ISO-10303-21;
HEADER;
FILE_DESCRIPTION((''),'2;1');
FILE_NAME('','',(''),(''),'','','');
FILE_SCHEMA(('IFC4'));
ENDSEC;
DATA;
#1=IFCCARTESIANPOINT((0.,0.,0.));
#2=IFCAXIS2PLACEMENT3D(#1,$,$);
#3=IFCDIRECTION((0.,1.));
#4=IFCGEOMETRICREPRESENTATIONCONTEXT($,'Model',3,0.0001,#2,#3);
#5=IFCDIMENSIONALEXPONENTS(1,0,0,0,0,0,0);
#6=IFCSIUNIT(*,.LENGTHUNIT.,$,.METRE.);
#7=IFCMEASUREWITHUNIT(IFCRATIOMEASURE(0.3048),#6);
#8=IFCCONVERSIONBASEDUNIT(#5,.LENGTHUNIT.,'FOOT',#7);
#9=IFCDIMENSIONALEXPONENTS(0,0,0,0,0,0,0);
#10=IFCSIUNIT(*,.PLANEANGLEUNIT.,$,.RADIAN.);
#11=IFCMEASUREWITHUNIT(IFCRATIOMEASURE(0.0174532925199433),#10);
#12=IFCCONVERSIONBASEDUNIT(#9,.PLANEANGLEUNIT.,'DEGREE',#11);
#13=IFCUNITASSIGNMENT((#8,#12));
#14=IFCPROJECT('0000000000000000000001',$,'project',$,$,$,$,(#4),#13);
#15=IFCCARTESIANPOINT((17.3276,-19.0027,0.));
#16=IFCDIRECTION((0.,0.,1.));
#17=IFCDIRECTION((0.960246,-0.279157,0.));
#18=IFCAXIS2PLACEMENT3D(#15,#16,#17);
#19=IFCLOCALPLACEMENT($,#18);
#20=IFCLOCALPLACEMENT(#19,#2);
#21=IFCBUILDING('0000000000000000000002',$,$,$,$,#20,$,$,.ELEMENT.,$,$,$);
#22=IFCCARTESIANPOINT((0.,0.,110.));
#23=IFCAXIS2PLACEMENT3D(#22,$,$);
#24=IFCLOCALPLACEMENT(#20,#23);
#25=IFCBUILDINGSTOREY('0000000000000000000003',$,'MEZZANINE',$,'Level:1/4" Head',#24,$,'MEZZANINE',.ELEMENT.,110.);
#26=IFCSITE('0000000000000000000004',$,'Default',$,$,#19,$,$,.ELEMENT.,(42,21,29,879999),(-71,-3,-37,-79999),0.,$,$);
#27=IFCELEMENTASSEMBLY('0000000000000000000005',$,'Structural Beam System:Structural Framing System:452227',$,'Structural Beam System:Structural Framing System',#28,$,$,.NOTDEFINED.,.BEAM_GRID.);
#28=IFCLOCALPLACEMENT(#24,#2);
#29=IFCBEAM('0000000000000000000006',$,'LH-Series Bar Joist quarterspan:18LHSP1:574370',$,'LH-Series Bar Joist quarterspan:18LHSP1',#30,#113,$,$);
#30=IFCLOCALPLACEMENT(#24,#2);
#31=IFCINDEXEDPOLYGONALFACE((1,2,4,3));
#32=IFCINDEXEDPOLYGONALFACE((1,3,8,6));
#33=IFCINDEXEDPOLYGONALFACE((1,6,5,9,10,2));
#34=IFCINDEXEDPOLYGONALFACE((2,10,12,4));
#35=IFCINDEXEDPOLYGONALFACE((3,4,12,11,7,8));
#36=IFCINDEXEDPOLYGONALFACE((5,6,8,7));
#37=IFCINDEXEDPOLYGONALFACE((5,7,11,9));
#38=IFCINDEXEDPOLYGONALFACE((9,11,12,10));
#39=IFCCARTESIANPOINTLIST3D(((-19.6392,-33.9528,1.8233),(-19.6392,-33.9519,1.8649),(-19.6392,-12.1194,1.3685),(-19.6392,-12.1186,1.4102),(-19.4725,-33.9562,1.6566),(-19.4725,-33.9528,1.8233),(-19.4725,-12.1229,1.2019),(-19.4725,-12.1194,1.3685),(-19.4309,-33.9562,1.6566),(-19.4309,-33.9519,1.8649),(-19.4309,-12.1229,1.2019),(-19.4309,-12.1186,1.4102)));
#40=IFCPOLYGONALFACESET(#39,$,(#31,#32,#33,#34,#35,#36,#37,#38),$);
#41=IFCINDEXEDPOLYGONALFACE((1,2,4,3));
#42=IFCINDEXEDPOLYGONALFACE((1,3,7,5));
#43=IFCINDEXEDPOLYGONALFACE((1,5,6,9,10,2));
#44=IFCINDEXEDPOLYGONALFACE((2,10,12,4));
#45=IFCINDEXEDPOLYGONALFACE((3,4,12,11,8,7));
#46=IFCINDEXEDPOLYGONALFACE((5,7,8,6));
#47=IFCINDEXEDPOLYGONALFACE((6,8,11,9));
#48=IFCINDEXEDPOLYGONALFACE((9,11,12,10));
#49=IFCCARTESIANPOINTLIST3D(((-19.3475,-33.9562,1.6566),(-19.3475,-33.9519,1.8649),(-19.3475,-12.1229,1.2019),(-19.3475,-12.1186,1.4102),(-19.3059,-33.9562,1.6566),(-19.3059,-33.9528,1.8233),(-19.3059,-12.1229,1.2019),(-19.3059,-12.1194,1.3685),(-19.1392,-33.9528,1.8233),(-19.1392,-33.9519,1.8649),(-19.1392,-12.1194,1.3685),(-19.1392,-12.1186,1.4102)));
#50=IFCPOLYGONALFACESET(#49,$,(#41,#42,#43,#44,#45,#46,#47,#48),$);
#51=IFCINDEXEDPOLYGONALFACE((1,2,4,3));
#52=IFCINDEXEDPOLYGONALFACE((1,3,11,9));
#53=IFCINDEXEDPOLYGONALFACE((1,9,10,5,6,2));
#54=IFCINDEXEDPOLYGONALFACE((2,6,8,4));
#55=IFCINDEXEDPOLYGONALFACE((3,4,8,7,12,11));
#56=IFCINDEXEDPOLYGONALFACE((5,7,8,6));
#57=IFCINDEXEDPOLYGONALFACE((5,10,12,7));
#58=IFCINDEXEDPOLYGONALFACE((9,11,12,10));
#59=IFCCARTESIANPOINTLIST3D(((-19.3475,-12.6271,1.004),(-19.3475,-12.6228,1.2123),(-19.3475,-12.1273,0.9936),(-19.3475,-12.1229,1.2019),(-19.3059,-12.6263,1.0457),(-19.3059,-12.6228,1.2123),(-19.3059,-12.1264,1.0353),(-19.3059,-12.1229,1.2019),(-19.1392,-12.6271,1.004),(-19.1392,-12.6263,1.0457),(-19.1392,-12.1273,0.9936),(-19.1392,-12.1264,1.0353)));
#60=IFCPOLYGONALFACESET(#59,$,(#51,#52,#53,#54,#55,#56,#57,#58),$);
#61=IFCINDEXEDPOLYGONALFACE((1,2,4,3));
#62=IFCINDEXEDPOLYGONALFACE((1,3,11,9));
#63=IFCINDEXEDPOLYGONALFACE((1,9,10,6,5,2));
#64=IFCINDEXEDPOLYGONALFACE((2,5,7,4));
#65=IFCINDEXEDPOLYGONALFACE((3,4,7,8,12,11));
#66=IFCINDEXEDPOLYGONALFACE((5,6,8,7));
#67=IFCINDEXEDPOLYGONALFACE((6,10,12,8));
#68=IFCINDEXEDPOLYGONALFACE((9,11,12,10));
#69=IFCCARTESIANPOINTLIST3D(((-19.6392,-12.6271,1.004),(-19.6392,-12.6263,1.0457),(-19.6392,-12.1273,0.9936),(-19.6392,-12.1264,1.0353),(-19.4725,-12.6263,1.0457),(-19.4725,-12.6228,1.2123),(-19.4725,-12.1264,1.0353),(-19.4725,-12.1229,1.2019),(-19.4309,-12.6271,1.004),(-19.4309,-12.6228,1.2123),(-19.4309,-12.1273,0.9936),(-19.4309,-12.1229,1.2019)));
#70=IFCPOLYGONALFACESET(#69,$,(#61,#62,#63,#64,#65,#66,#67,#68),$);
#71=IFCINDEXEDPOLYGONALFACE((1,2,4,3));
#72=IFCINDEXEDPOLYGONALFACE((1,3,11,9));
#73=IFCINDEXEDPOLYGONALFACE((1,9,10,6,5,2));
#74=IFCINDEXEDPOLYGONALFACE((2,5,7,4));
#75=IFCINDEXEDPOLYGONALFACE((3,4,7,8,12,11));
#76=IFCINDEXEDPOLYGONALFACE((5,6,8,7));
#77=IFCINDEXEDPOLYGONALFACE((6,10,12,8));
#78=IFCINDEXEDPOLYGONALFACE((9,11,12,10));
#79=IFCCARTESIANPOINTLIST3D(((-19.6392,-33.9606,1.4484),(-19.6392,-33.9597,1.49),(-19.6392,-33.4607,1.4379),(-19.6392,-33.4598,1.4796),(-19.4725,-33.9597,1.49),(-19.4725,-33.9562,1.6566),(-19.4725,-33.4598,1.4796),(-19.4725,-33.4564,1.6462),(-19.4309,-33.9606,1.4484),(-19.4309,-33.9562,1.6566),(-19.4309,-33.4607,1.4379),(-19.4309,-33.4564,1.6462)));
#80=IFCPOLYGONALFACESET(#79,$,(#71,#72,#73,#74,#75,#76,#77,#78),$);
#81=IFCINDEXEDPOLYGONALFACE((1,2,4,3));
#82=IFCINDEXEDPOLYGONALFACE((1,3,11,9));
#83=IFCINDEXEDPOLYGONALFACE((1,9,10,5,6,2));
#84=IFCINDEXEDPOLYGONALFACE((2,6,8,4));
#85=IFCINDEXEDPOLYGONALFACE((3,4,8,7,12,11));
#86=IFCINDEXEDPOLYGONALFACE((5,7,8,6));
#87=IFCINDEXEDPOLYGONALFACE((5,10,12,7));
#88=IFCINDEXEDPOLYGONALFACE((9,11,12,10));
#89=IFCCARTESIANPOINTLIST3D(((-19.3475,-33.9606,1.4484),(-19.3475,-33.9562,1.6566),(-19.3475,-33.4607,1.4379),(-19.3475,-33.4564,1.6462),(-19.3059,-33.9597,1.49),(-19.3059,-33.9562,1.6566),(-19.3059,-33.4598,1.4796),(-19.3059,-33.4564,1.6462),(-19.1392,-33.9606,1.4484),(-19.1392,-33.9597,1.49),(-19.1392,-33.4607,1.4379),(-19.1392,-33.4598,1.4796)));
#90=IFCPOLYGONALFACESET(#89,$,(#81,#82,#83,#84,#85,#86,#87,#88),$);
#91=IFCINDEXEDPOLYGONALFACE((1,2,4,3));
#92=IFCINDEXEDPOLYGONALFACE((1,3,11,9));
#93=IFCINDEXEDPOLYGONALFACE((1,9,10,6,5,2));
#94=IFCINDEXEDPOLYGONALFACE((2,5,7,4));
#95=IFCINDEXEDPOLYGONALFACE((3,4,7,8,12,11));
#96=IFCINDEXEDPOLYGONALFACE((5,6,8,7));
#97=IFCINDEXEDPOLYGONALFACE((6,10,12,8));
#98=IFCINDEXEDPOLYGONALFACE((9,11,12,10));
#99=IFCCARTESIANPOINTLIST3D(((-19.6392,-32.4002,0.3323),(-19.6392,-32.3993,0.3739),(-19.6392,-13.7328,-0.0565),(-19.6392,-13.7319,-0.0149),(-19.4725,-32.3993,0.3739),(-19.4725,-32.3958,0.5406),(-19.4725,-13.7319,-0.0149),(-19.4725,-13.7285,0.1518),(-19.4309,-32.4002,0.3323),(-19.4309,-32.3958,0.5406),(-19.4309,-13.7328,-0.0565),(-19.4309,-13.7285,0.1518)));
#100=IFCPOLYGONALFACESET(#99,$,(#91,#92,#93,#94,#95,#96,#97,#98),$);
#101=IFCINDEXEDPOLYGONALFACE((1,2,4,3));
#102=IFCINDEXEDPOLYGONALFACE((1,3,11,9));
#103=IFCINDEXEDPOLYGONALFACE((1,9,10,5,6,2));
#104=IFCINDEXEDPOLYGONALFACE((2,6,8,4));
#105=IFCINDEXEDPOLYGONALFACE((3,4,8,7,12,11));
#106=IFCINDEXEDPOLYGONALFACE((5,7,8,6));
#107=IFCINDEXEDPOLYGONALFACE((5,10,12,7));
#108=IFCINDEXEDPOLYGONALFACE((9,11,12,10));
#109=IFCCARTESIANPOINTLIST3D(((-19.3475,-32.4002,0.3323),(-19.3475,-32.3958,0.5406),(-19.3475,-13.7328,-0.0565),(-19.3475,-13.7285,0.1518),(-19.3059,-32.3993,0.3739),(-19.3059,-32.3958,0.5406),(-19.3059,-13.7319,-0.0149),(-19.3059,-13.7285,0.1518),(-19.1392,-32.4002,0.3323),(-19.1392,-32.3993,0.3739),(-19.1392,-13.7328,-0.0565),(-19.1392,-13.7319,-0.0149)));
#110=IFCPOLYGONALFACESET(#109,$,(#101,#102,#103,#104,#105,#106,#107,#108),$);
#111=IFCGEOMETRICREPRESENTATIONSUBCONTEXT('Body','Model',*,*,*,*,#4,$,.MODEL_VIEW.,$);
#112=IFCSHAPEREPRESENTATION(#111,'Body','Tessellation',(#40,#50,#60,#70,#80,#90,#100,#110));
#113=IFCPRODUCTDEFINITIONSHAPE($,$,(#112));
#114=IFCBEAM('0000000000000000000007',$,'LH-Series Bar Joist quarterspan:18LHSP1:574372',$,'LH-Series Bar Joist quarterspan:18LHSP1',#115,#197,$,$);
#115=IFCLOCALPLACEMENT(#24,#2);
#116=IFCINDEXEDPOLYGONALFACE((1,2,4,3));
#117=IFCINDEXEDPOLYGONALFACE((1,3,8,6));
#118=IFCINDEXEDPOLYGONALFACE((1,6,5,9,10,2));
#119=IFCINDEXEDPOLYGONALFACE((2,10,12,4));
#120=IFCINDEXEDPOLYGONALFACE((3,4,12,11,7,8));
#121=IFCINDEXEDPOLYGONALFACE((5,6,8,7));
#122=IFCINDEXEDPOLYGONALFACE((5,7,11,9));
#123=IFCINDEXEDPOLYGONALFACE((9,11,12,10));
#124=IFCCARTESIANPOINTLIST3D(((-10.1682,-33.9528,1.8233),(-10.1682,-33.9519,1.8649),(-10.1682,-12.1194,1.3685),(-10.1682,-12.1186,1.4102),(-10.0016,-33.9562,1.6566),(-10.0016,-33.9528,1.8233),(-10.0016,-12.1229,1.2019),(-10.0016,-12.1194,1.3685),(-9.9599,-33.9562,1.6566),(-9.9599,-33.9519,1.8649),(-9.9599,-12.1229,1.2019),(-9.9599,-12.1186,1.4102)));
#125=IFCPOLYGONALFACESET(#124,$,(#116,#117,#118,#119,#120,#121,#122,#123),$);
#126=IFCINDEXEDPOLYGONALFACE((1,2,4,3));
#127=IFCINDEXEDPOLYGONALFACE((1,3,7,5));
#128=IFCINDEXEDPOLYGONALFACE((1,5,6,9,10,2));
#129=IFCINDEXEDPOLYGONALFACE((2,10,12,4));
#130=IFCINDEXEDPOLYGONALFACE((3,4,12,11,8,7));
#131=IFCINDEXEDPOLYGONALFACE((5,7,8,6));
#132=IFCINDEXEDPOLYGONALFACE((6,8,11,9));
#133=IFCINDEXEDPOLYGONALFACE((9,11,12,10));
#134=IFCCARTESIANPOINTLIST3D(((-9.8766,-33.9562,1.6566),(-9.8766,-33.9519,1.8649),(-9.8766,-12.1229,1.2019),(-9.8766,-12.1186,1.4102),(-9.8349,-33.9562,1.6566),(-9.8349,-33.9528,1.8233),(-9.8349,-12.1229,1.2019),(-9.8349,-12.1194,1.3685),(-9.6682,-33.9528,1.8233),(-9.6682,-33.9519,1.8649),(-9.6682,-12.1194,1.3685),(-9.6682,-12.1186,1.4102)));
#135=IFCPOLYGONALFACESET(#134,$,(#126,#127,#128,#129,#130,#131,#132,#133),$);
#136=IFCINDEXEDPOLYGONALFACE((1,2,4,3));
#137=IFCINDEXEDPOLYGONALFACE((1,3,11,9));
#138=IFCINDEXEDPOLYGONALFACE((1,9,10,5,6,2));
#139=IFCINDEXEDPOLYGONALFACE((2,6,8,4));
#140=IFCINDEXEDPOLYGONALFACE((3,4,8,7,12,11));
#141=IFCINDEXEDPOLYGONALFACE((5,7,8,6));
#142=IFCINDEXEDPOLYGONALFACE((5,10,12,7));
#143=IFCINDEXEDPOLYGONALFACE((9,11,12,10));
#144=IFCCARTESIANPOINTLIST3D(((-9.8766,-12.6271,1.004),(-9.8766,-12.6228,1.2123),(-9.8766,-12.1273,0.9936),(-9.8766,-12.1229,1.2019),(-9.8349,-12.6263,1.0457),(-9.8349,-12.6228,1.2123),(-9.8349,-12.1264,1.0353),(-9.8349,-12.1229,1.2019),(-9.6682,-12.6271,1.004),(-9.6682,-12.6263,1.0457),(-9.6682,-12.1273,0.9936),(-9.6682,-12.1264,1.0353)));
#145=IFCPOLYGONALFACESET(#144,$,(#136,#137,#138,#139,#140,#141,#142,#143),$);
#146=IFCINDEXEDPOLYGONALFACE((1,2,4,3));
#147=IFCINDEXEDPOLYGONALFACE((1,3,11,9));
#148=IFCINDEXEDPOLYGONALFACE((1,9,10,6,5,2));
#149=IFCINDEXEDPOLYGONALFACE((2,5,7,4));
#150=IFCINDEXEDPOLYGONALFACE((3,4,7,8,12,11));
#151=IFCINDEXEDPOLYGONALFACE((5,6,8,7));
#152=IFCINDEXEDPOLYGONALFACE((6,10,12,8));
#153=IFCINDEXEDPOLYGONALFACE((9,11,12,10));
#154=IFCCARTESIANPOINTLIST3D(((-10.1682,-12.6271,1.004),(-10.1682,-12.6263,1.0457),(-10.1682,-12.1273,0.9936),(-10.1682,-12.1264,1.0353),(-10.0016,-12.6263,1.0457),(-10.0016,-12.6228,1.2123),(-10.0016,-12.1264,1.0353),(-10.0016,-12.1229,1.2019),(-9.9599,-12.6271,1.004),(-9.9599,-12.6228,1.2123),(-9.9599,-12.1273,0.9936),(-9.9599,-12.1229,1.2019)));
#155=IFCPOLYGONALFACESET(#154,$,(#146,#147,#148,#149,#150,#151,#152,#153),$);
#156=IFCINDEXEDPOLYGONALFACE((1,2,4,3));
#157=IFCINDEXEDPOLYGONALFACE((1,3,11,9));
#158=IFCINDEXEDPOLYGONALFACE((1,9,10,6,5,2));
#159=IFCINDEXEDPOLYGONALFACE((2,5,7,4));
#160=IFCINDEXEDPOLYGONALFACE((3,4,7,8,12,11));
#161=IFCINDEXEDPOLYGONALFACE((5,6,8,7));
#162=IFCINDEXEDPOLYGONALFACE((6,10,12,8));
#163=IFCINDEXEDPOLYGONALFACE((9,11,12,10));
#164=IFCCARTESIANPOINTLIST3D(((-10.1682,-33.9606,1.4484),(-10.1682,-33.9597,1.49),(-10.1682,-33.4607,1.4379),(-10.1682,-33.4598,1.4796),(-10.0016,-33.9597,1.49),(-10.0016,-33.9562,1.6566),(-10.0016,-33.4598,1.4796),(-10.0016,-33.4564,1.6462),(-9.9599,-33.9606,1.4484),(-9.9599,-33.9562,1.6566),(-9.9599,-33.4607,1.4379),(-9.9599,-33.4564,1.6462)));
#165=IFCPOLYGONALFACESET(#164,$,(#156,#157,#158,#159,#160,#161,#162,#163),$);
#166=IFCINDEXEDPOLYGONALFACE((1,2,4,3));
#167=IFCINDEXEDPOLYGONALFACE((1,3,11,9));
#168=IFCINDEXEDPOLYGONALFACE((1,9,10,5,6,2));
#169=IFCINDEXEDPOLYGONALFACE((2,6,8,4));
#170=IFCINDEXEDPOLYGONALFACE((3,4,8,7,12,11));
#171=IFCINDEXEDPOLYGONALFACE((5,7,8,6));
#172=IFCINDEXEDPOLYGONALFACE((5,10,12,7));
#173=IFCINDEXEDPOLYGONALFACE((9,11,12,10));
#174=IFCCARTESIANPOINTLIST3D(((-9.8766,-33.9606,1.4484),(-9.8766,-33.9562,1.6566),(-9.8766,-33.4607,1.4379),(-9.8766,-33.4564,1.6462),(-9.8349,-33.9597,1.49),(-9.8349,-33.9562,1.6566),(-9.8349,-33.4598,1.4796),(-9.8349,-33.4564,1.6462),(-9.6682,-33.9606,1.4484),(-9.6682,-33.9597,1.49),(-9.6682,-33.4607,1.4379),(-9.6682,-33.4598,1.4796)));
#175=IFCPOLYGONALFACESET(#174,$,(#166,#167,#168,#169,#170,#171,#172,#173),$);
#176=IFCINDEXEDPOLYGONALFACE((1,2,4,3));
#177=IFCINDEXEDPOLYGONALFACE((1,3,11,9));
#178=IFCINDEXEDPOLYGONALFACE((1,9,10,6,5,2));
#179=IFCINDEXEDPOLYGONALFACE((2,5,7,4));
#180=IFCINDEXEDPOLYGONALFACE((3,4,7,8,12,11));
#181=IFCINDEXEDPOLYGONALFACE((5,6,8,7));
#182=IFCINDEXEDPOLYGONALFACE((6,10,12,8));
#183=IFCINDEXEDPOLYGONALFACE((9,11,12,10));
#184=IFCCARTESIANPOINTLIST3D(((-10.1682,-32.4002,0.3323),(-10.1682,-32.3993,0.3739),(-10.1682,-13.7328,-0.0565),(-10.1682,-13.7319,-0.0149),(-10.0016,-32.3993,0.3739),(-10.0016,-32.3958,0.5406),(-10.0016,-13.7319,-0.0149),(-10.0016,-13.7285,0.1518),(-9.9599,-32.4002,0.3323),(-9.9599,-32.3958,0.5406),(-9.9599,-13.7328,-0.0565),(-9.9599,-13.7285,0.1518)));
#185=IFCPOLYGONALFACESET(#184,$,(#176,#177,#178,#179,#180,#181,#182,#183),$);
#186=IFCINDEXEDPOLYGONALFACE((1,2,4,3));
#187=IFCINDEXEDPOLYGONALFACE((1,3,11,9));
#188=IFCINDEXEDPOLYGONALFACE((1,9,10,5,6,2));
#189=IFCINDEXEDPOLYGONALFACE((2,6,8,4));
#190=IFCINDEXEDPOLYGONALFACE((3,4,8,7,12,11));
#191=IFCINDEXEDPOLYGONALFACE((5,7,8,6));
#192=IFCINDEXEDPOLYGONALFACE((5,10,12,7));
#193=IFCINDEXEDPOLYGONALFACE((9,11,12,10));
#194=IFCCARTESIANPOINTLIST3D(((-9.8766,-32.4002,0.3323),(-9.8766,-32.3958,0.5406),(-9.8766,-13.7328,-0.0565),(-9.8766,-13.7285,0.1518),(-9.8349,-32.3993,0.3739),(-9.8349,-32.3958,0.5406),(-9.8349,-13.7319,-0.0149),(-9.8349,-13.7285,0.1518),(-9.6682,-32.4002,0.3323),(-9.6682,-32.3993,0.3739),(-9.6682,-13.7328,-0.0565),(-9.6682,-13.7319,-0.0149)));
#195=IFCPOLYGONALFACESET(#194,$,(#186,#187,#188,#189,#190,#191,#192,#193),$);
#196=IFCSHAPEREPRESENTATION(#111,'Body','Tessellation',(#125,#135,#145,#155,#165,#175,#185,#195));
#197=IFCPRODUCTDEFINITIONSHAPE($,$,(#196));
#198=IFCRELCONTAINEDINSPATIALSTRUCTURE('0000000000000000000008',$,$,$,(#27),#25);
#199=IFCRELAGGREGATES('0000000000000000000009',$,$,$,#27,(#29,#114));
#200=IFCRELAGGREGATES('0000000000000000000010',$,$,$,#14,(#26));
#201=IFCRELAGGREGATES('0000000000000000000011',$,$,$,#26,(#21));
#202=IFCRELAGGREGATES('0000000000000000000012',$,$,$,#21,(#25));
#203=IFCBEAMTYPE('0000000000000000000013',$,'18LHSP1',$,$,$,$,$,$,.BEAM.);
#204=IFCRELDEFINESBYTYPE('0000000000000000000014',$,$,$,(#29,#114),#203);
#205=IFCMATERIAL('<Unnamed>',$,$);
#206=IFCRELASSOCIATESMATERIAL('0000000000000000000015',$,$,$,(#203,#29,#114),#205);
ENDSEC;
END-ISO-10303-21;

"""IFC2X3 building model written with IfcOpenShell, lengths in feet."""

from ifc_helpers import new_model, entity, si_unit, converted_unit, direction, frame, origin, place, context, subcontext, project, spatial, polyline, outline, extrude, source, transform, mapped, material, type_object, type_shapes, element, aggregate, save


model = new_model("IFC2X3")

# Units and contexts
model_context = context("Model", 3, precision=0.0001, world=origin(), true_north=direction((0.0, 1.0)))
body_context = subcontext(model_context, "Body", "Model", "MODEL_VIEW")
ifc_project = project(units=[converted_unit("LENGTHUNIT", "FOOT", entity("IfcRatioMeasure", 0.3048), si_unit("LENGTHUNIT", "METRE"), dimensions=[1, 0, 0, 0, 0, 0, 0]), converted_unit("PLANEANGLEUNIT", "DEGREE", entity("IfcRatioMeasure", 0.0174532925199433), si_unit("PLANEANGLEUNIT", "RADIAN"), dimensions=[0, 0, 0, 0, 0, 0, 0])], contexts=[model_context])

# Site, building, storey
site_placement = place(None, frame((17.3276, -19.0027, 0.0), z_axis=(0.0, 0.0, 1.0), x_axis=(0.960246, -0.279157, 0.0)))
site = spatial("IfcSite", under=ifc_project, at=site_placement, Name="Default", CompositionType="ELEMENT", RefLatitude=(42, 21, 29, 879999), RefLongitude=(-71, -3, -37, -79999), RefElevation=0.0)
building_placement = place(site_placement, origin())
building = spatial("IfcBuilding", under=site, at=building_placement, CompositionType="ELEMENT")
storey_placement = place(building_placement, frame((0.0, 0.0, 110.0)))
storey = spatial("IfcBuildingStorey", under=building, at=storey_placement, Name="MEZZANINE", ObjectType="Level:1/4\" Head", LongName="MEZZANINE", CompositionType="ELEMENT", Elevation=110.0)

# Element assembly, beams
assembly_1_placement = place(storey_placement, origin())
assembly_1 = element("IfcElementAssembly", 1, at=assembly_1_placement, inside=storey, Name="Structural Beam System:Structural Framing System:452227", ObjectType="Structural Beam System:Structural Framing System", AssemblyPlace="NOTDEFINED", PredefinedType="BEAM_GRID")
ifc_material_1 = material(Name="<Unnamed>")
beam_type_1 = type_object("IfcBeamType", Name="18LHSP1", PredefinedType="BEAM", material=ifc_material_1)
shared_shape_1 = source(origin(), body_context, "Body", "SweptSolid", [
    extrude(outline(polyline([(-0.0833, -0.125), (-0.0417, -0.125), (-0.0417, 0.0417), (0.125, 0.0417), (0.125, 0.0833), (-0.0833, 0.0833), (-0.0833, -0.125)])), frame((-10.919, -0.125, 0.6667), z_axis=(1.0, 0.0, 0.0), x_axis=(0.0, 0.0, -1.0)), (0.0, 0.0, 1.0), 21.8381),
    extrude(outline(polyline([(-0.0833, -0.0833), (0.125, -0.0833), (0.125, -0.0417), (-0.0417, -0.0417), (-0.0417, 0.125), (-0.0833, 0.125), (-0.0833, -0.0833)])), frame((-10.919, 0.125, 0.6667), z_axis=(1.0, 0.0, 0.0), x_axis=(0.0, 0.0, -1.0)), (0.0, 0.0, 1.0), 21.8381),
    extrude(outline(polyline([(-0.125, -0.0833), (0.0833, -0.0833), (0.0833, 0.125), (0.0417, 0.125), (0.0417, -0.0417), (-0.125, -0.0417), (-0.125, -0.0833)])), frame((-10.919, 0.125, 0.4167), z_axis=(1.0, 0.0, 0.0), x_axis=(0.0, 0.0, -1.0)), (0.0, 0.0, 1.0), 0.5),
    extrude(outline(polyline([(0.0417, -0.125), (0.0833, -0.125), (0.0833, 0.0833), (-0.125, 0.0833), (-0.125, 0.0417), (0.0417, 0.0417), (0.0417, -0.125)])), frame((-10.919, -0.125, 0.4167), z_axis=(1.0, 0.0, 0.0), x_axis=(0.0, 0.0, -1.0)), (0.0, 0.0, 1.0), 0.5),
    extrude(outline(polyline([(0.0417, -0.125), (0.0833, -0.125), (0.0833, 0.0833), (-0.125, 0.0833), (-0.125, 0.0417), (0.0417, 0.0417), (0.0417, -0.125)])), frame((10.419, -0.125, 0.4167), z_axis=(1.0, 0.0, 0.0), x_axis=(0.0, 0.0, -1.0)), (0.0, 0.0, 1.0), 0.5),
    extrude(outline(polyline([(-0.125, -0.0833), (0.0833, -0.0833), (0.0833, 0.125), (0.0417, 0.125), (0.0417, -0.0417), (-0.125, -0.0417), (-0.125, -0.0833)])), frame((10.419, 0.125, 0.4167), z_axis=(1.0, 0.0, 0.0), x_axis=(0.0, 0.0, -1.0)), (0.0, 0.0, 1.0), 0.5),
    extrude(outline(polyline([(0.0417, -0.125), (0.0833, -0.125), (0.0833, 0.0833), (-0.125, 0.0833), (-0.125, 0.0417), (0.0417, 0.0417), (0.0417, -0.125)])), frame((-9.3357, -0.125, -0.6667), z_axis=(1.0, 0.0, 0.0), x_axis=(0.0, 0.0, -1.0)), (0.0, 0.0, 1.0), 18.6714),
    extrude(outline(polyline([(-0.125, -0.0833), (0.0833, -0.0833), (0.0833, 0.125), (0.0417, 0.125), (0.0417, -0.0417), (-0.125, -0.0417), (-0.125, -0.0833)])), frame((-9.3357, 0.125, -0.6667), z_axis=(1.0, 0.0, 0.0), x_axis=(0.0, 0.0, -1.0)), (0.0, 0.0, 1.0), 18.6714),
])
type_shapes(beam_type_1, [shared_shape_1])
beam_1_placement = place(assembly_1_placement, frame((-19.3892, -23.0509, 0.8877), z_axis=(0.0, 0.020824, 0.999783), x_axis=(0.0, -0.999783, 0.020824)))
beam_1 = element("IfcBeam", 2, at=beam_1_placement, type_object=beam_type_1, material=ifc_material_1, Name="LH-Series Bar Joist quarterspan:18LHSP1:574370", ObjectType="LH-Series Bar Joist quarterspan:18LHSP1", context=body_context, shape_type="MappedRepresentation", body=[
    mapped(shared_shape_1, transform((0.0, 0.0, 0.0), scale=1.0)),
])
beam_2_placement = place(assembly_1_placement, frame((-9.9182, -23.0509, 0.8877), z_axis=(0.0, 0.020824, 0.999783), x_axis=(0.0, -0.999783, 0.020824)))
beam_2 = element("IfcBeam", 3, at=beam_2_placement, type_object=beam_type_1, material=ifc_material_1, Name="LH-Series Bar Joist quarterspan:18LHSP1:574372", ObjectType="LH-Series Bar Joist quarterspan:18LHSP1", context=body_context, shape_type="MappedRepresentation", body=[
    mapped(shared_shape_1, transform((0.0, 0.0, 0.0), scale=1.0)),
])
aggregate(assembly_1, [beam_1, beam_2])

save(model, "model.ifc")
